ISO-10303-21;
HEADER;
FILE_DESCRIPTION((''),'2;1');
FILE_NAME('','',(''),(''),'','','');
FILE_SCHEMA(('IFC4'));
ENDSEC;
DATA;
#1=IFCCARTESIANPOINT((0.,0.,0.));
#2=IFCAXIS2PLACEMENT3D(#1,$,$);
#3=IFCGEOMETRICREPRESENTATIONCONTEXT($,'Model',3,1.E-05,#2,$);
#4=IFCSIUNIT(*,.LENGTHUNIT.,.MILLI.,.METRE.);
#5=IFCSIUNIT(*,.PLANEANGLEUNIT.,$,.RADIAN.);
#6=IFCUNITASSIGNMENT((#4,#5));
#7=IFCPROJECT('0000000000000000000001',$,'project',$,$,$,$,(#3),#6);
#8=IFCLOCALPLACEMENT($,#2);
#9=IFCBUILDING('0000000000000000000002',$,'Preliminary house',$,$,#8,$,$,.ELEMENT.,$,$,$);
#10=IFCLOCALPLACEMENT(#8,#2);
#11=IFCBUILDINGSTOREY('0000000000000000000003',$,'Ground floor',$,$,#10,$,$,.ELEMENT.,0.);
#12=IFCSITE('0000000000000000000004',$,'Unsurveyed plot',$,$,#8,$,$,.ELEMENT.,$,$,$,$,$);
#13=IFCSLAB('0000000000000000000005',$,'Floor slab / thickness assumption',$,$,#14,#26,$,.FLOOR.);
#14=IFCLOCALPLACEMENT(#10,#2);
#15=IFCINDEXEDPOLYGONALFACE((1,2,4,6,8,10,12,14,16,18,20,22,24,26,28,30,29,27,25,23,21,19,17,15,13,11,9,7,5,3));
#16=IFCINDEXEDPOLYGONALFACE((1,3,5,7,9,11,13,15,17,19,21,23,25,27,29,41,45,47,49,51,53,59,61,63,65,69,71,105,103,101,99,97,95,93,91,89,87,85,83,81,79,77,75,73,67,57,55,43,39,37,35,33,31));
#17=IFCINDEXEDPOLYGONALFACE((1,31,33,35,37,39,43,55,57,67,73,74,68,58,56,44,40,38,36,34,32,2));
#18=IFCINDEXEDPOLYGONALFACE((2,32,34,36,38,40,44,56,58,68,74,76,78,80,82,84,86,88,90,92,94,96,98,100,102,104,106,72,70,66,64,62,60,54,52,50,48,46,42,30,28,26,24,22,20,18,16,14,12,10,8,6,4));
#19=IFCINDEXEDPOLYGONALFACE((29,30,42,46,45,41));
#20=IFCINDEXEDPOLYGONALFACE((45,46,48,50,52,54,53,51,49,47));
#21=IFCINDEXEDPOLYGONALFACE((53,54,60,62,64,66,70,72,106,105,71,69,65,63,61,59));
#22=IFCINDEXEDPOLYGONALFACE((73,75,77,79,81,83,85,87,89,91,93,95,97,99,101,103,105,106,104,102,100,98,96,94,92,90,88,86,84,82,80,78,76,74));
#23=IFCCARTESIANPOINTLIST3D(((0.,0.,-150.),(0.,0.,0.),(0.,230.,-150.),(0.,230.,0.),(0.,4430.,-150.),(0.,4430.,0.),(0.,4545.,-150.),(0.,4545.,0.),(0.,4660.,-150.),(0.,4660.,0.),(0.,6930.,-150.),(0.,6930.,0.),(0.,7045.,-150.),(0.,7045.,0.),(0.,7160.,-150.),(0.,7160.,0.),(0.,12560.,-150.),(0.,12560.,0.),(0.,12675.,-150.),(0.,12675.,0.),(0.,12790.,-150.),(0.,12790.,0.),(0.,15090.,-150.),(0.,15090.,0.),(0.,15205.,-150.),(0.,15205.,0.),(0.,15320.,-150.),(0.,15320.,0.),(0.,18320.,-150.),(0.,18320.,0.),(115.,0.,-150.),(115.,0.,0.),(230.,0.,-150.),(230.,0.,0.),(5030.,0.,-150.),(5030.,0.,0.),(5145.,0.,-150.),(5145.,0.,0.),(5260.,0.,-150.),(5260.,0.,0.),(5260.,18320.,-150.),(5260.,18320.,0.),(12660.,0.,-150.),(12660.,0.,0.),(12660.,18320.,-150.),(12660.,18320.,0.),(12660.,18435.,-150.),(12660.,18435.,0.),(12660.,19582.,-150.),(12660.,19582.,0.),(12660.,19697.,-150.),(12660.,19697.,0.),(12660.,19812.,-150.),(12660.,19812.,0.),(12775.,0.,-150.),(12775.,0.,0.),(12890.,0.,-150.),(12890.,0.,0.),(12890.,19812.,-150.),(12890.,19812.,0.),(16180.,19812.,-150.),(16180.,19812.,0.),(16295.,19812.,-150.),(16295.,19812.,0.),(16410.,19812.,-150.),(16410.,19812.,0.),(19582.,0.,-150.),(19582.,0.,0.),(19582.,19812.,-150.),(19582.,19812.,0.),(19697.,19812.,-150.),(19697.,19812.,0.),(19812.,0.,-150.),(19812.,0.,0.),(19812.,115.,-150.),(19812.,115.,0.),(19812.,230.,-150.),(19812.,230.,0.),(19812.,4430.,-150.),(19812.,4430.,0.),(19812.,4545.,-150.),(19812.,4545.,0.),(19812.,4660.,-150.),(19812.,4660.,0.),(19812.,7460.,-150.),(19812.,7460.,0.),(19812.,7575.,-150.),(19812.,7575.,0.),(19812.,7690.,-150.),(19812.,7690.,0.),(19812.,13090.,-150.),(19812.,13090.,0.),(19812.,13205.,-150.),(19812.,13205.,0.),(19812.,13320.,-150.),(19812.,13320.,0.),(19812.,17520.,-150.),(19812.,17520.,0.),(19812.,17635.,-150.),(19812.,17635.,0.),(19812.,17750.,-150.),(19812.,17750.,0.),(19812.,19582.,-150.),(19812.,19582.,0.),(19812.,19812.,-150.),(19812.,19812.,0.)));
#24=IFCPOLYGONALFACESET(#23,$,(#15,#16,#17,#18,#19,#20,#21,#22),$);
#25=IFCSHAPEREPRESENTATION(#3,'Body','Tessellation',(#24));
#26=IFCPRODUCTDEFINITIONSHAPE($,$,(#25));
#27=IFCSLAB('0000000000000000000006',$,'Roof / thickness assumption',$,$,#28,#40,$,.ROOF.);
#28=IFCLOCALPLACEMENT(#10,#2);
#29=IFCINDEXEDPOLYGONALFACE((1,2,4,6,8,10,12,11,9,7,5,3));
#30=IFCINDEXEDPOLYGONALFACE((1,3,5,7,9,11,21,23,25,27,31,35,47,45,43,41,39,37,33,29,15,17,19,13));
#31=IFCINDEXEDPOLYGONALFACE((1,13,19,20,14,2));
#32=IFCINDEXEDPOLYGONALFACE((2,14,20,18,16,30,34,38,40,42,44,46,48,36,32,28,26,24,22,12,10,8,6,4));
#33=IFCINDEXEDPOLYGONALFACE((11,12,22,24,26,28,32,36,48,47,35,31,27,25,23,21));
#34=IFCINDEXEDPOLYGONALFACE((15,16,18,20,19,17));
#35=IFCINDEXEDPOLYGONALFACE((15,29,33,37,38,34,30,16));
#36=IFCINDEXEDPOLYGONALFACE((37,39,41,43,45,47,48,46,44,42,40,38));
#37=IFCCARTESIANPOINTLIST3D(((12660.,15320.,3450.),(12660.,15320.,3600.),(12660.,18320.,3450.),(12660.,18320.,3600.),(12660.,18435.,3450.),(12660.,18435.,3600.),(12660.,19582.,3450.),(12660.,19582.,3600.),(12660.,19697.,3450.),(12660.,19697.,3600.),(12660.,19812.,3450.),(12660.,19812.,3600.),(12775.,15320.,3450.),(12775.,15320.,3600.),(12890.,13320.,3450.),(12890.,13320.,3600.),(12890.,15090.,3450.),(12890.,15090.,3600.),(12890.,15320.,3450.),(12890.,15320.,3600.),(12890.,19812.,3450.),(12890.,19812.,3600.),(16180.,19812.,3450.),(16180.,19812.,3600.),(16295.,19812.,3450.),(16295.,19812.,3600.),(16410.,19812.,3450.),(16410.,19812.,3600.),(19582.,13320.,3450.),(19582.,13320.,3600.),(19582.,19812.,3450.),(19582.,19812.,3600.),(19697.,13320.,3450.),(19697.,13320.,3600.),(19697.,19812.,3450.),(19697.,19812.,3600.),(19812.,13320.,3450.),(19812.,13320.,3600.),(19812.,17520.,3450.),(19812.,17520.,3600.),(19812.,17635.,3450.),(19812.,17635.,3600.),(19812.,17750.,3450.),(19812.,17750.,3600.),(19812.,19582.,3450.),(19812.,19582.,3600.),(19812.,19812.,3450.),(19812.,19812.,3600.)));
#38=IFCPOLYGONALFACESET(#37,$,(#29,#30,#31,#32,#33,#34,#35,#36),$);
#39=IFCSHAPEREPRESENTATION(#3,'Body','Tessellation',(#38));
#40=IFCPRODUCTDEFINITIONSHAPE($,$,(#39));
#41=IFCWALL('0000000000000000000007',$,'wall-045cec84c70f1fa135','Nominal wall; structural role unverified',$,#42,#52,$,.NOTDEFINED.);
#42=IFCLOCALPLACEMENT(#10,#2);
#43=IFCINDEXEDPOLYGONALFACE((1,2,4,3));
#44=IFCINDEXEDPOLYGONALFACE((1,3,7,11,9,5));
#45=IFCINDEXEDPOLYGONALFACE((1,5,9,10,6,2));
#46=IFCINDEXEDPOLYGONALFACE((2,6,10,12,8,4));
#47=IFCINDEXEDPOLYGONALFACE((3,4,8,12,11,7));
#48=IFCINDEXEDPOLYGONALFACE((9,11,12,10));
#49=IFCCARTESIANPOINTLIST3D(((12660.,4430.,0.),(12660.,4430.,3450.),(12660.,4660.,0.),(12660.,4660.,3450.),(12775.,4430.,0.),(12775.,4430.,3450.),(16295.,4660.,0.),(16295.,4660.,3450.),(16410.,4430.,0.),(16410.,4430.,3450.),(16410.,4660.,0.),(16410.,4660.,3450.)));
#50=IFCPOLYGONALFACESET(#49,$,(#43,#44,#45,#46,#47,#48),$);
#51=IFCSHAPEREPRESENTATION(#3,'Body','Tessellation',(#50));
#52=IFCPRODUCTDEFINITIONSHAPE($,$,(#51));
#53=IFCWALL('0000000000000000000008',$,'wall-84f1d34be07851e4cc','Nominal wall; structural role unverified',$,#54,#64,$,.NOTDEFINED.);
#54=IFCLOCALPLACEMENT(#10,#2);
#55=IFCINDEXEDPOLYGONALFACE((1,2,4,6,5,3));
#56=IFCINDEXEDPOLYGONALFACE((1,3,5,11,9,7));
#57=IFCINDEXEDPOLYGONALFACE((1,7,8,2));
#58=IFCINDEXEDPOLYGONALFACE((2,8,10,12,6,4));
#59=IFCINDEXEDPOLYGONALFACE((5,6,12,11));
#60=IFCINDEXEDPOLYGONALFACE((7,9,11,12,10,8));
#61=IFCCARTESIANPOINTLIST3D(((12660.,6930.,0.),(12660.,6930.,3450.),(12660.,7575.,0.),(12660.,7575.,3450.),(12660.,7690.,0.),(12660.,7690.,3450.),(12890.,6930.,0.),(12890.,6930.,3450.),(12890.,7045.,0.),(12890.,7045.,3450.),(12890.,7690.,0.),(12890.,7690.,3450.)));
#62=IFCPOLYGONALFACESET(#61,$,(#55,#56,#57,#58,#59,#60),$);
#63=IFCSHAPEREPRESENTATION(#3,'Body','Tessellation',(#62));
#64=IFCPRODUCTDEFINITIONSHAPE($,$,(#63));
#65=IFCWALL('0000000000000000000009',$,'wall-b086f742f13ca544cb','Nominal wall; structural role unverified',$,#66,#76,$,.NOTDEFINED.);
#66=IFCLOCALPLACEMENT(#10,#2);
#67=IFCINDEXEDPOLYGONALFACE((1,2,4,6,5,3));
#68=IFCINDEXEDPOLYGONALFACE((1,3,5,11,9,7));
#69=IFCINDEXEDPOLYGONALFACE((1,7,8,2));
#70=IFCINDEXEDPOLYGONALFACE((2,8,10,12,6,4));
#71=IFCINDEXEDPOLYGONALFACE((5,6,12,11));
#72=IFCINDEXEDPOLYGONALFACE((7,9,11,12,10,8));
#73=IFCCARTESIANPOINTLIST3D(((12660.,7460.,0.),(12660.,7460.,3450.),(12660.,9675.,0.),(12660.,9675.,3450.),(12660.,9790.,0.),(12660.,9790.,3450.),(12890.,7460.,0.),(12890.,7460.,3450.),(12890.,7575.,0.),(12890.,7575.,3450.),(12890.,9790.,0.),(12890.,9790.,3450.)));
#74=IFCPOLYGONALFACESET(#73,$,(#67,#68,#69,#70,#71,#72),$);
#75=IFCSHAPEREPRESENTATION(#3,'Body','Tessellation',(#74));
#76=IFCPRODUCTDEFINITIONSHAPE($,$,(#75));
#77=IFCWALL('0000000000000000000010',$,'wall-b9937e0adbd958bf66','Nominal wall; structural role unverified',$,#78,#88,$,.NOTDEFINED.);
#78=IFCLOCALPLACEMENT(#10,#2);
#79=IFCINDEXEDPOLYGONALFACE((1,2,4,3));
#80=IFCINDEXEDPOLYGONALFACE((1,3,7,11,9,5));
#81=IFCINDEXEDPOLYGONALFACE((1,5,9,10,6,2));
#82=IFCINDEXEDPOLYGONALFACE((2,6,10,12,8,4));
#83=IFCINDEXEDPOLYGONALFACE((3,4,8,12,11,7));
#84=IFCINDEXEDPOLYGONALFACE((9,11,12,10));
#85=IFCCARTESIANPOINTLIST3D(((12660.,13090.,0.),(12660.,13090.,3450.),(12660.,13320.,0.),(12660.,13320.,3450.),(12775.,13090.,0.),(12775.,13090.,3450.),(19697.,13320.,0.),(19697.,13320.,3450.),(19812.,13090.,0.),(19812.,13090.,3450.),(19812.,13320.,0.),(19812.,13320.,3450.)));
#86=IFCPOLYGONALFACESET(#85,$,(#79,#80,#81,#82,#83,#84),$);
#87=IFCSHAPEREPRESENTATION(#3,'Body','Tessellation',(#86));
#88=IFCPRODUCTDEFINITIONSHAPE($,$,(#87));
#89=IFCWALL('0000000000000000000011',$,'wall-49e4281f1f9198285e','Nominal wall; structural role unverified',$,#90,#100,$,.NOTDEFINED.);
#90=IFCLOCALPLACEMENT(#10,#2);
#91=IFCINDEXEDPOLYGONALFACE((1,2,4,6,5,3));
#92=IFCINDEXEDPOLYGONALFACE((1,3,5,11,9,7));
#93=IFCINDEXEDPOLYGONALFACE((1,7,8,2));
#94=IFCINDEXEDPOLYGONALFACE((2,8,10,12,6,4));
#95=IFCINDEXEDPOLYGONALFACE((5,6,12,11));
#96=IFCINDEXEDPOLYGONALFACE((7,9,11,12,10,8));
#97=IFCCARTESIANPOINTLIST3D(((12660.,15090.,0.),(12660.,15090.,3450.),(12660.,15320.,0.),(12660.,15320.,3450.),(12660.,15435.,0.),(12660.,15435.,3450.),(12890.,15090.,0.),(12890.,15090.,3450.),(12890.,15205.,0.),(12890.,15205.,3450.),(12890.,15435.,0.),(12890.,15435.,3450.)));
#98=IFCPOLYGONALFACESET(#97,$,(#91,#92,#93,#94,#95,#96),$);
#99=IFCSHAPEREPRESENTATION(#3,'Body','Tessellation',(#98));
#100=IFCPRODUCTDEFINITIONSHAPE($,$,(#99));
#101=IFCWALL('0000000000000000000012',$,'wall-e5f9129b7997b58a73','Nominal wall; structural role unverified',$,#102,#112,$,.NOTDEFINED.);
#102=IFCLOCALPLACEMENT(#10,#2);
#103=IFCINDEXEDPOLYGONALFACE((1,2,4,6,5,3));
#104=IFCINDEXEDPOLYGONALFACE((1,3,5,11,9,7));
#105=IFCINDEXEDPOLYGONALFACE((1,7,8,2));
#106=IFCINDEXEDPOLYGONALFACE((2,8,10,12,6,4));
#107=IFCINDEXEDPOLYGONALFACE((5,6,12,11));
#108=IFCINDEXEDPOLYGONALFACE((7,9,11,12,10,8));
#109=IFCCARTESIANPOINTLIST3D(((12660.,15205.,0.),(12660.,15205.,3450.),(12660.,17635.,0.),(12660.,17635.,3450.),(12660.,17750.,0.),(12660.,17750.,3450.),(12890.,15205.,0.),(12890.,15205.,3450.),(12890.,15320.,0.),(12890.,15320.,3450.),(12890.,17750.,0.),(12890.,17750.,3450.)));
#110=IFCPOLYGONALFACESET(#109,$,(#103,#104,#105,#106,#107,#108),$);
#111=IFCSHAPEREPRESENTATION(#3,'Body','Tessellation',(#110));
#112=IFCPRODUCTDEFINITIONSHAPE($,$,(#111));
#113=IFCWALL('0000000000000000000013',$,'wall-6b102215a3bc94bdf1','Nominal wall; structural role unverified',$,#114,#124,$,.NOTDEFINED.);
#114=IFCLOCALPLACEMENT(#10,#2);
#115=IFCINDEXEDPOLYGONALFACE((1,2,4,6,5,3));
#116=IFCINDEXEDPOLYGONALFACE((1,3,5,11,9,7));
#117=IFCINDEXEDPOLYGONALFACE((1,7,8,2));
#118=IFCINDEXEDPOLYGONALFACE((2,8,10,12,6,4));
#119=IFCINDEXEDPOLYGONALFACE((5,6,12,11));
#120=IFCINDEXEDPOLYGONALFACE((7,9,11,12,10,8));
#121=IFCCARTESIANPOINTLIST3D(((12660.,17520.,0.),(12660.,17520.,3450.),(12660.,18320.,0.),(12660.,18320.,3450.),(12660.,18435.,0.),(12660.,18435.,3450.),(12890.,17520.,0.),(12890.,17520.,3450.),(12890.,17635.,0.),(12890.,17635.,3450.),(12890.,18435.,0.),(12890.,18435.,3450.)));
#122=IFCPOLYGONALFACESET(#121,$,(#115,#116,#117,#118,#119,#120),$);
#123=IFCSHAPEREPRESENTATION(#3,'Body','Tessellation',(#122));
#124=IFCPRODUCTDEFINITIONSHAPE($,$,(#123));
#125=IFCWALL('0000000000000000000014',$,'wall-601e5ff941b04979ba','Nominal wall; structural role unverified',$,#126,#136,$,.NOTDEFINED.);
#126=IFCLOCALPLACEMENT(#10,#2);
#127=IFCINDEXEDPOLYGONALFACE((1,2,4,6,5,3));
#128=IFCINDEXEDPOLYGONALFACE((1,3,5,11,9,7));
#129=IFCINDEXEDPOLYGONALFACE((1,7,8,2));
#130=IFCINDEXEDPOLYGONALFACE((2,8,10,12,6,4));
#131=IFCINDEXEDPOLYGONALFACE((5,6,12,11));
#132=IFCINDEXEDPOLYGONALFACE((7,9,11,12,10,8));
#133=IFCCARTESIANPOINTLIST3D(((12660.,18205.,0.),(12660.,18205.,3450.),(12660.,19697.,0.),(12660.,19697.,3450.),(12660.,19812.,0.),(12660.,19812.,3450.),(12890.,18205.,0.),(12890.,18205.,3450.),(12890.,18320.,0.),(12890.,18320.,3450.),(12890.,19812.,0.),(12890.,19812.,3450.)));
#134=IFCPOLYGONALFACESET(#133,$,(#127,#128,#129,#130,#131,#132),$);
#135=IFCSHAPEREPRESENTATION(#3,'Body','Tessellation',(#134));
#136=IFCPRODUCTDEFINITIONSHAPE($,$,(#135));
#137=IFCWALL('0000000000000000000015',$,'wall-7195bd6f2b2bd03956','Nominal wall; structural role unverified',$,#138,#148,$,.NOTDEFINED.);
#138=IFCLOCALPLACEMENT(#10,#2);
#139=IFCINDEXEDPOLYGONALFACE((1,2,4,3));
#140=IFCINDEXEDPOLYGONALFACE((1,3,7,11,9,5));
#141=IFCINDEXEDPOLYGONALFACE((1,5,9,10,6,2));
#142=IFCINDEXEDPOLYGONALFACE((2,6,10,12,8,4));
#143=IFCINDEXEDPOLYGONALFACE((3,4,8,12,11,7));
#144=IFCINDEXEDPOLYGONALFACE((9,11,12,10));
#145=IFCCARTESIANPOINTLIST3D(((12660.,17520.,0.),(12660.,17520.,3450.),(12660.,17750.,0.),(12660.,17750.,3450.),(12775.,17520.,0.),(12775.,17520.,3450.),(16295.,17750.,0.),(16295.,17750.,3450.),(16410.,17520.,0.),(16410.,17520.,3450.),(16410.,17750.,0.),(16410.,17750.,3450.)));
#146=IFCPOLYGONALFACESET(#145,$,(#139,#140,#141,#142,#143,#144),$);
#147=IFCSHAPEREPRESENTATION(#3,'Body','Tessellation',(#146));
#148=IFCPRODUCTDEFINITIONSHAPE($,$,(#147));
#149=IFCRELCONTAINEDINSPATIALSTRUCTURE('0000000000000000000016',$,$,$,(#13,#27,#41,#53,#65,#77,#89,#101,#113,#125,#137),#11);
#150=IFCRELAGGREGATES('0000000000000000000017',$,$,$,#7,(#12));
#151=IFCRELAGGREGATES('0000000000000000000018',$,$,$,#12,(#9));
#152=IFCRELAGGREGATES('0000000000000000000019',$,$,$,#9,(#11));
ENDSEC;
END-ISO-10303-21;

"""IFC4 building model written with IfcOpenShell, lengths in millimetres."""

from ifc_helpers import new_model, si_unit, frame, origin, place, context, project, spatial, polyline, outline, extrude, element, save


model = new_model("IFC4")

# Units and contexts
model_context = context("Model", 3, precision=1e-05, world=origin())
ifc_project = project(units=[si_unit("LENGTHUNIT", "METRE", prefix="MILLI"), si_unit("PLANEANGLEUNIT", "RADIAN")], contexts=[model_context])

# Site, building, storey
placement_1 = place(None, origin())
site = spatial("IfcSite", under=ifc_project, at=placement_1, Name="Unsurveyed plot", CompositionType="ELEMENT")
building = spatial("IfcBuilding", under=site, at=placement_1, Name="Preliminary house", CompositionType="ELEMENT")
placement_2 = place(placement_1, origin())
storey = spatial("IfcBuildingStorey", under=building, at=placement_2, Name="Ground floor", CompositionType="ELEMENT", Elevation=0.0)

# Slabs
element("IfcSlab", 1, at=placement_2, inside=storey, Name="Floor slab / thickness assumption", PredefinedType="FLOOR", context=model_context, shape_type="SweptSolid", body=[
    extrude(outline(polyline([(0.0, 0.0), (0.0, 230.0), (0.0, 4430.0), (0.0, 4545.0), (0.0, 4660.0), (0.0, 6930.0), (0.0, 7045.0), (0.0, 7160.0), (0.0, 12560.0), (0.0, 12675.0), (0.0, 12790.0), (0.0, 15090.0), (0.0, 15205.0), (0.0, 15320.0), (0.0, 18320.0), (5260.0, 18320.0), (12660.0, 18320.0), (12660.0, 18435.0), (12660.0, 19582.0), (12660.0, 19697.0), (12660.0, 19812.0), (12890.0, 19812.0), (16180.0, 19812.0), (16295.0, 19812.0), (16410.0, 19812.0), (19582.0, 19812.0), (19697.0, 19812.0), (19812.0, 19812.0), (19812.0, 19582.0), (19812.0, 17750.0), (19812.0, 17635.0), (19812.0, 17520.0), (19812.0, 13320.0), (19812.0, 13205.0), (19812.0, 13090.0), (19812.0, 7690.0), (19812.0, 7575.0), (19812.0, 7460.0), (19812.0, 4660.0), (19812.0, 4545.0), (19812.0, 4430.0), (19812.0, 230.0), (19812.0, 115.0), (19812.0, 0.0), (19582.0, 0.0), (12890.0, 0.0), (12775.0, 0.0), (12660.0, 0.0), (5260.0, 0.0), (5145.0, 0.0), (5030.0, 0.0), (230.0, 0.0), (115.0, 0.0), (0.0, 0.0)])), frame((0.0, 0.0, -150.0)), (0.0, 0.0, 1.0), 150.0),
])
element("IfcSlab", 2, at=placement_2, inside=storey, Name="Roof / thickness assumption", PredefinedType="ROOF", context=model_context, shape_type="SweptSolid", body=[
    extrude(outline(polyline([(12660.0, 18435.0), (12660.0, 19582.0), (12660.0, 19697.0), (12660.0, 19812.0), (12890.0, 19812.0), (16180.0, 19812.0), (16295.0, 19812.0), (16410.0, 19812.0), (19582.0, 19812.0), (19697.0, 19812.0), (19812.0, 19812.0), (19812.0, 19582.0), (19812.0, 17750.0), (19812.0, 17635.0), (19812.0, 17520.0), (19812.0, 13320.0), (19697.0, 13320.0), (19582.0, 13320.0), (12890.0, 13320.0), (12890.0, 15090.0), (12890.0, 15320.0), (12775.0, 15320.0), (12660.0, 15320.0), (12660.0, 18320.0), (12660.0, 18435.0)])), frame((0.0, 0.0, 3450.0)), (0.0, 0.0, 1.0), 150.0),
])

# Walls
element("IfcWall", 3, at=placement_2, inside=storey, Name="wall-045cec84c70f1fa135", Description="Nominal wall; structural role unverified", PredefinedType="NOTDEFINED", context=model_context, shape_type="SweptSolid", body=[
    extrude(outline(polyline([(16295.0, 4660.0), (16410.0, 4660.0), (16410.0, 4430.0), (12775.0, 4430.0), (12660.0, 4430.0), (12660.0, 4660.0), (16295.0, 4660.0)])), origin(), (0.0, 0.0, 1.0), 3450.0),
])
element("IfcWall", 4, at=placement_2, inside=storey, Name="wall-84f1d34be07851e4cc", Description="Nominal wall; structural role unverified", PredefinedType="NOTDEFINED", context=model_context, shape_type="SweptSolid", body=[
    extrude(outline(polyline([(12660.0, 7575.0), (12660.0, 7690.0), (12890.0, 7690.0), (12890.0, 7045.0), (12890.0, 6930.0), (12660.0, 6930.0), (12660.0, 7575.0)])), origin(), (0.0, 0.0, 1.0), 3450.0),
])
element("IfcWall", 5, at=placement_2, inside=storey, Name="wall-b086f742f13ca544cb", Description="Nominal wall; structural role unverified", PredefinedType="NOTDEFINED", context=model_context, shape_type="SweptSolid", body=[
    extrude(outline(polyline([(12660.0, 9675.0), (12660.0, 9790.0), (12890.0, 9790.0), (12890.0, 7575.0), (12890.0, 7460.0), (12660.0, 7460.0), (12660.0, 9675.0)])), origin(), (0.0, 0.0, 1.0), 3450.0),
])

# Walls
element("IfcWall", 6, at=placement_2, inside=storey, Name="wall-b9937e0adbd958bf66", Description="Nominal wall; structural role unverified", PredefinedType="NOTDEFINED", context=model_context, shape_type="SweptSolid", body=[
    extrude(outline(polyline([(19697.0, 13320.0), (19812.0, 13320.0), (19812.0, 13090.0), (12775.0, 13090.0), (12660.0, 13090.0), (12660.0, 13320.0), (19697.0, 13320.0)])), origin(), (0.0, 0.0, 1.0), 3450.0),
])
element("IfcWall", 7, at=placement_2, inside=storey, Name="wall-49e4281f1f9198285e", Description="Nominal wall; structural role unverified", PredefinedType="NOTDEFINED", context=model_context, shape_type="SweptSolid", body=[
    extrude(outline(polyline([(12660.0, 15320.0), (12660.0, 15435.0), (12890.0, 15435.0), (12890.0, 15205.0), (12890.0, 15090.0), (12660.0, 15090.0), (12660.0, 15320.0)])), origin(), (0.0, 0.0, 1.0), 3450.0),
])
element("IfcWall", 8, at=placement_2, inside=storey, Name="wall-e5f9129b7997b58a73", Description="Nominal wall; structural role unverified", PredefinedType="NOTDEFINED", context=model_context, shape_type="SweptSolid", body=[
    extrude(outline(polyline([(12660.0, 17635.0), (12660.0, 17750.0), (12890.0, 17750.0), (12890.0, 15320.0), (12890.0, 15205.0), (12660.0, 15205.0), (12660.0, 17635.0)])), origin(), (0.0, 0.0, 1.0), 3450.0),
])
element("IfcWall", 9, at=placement_2, inside=storey, Name="wall-6b102215a3bc94bdf1", Description="Nominal wall; structural role unverified", PredefinedType="NOTDEFINED", context=model_context, shape_type="SweptSolid", body=[
    extrude(outline(polyline([(12660.0, 18320.0), (12660.0, 18435.0), (12890.0, 18435.0), (12890.0, 17635.0), (12890.0, 17520.0), (12660.0, 17520.0), (12660.0, 18320.0)])), origin(), (0.0, 0.0, 1.0), 3450.0),
])
element("IfcWall", 10, at=placement_2, inside=storey, Name="wall-601e5ff941b04979ba", Description="Nominal wall; structural role unverified", PredefinedType="NOTDEFINED", context=model_context, shape_type="SweptSolid", body=[
    extrude(outline(polyline([(12660.0, 19697.0), (12660.0, 19812.0), (12890.0, 19812.0), (12890.0, 18320.0), (12890.0, 18205.0), (12660.0, 18205.0), (12660.0, 19697.0)])), origin(), (0.0, 0.0, 1.0), 3450.0),
])
element("IfcWall", 11, at=placement_2, inside=storey, Name="wall-7195bd6f2b2bd03956", Description="Nominal wall; structural role unverified", PredefinedType="NOTDEFINED", context=model_context, shape_type="SweptSolid", body=[
    extrude(outline(polyline([(16295.0, 17750.0), (16410.0, 17750.0), (16410.0, 17520.0), (12775.0, 17520.0), (12660.0, 17520.0), (12660.0, 17750.0), (16295.0, 17750.0)])), origin(), (0.0, 0.0, 1.0), 3450.0),
])

save(model, "model.ifc")
